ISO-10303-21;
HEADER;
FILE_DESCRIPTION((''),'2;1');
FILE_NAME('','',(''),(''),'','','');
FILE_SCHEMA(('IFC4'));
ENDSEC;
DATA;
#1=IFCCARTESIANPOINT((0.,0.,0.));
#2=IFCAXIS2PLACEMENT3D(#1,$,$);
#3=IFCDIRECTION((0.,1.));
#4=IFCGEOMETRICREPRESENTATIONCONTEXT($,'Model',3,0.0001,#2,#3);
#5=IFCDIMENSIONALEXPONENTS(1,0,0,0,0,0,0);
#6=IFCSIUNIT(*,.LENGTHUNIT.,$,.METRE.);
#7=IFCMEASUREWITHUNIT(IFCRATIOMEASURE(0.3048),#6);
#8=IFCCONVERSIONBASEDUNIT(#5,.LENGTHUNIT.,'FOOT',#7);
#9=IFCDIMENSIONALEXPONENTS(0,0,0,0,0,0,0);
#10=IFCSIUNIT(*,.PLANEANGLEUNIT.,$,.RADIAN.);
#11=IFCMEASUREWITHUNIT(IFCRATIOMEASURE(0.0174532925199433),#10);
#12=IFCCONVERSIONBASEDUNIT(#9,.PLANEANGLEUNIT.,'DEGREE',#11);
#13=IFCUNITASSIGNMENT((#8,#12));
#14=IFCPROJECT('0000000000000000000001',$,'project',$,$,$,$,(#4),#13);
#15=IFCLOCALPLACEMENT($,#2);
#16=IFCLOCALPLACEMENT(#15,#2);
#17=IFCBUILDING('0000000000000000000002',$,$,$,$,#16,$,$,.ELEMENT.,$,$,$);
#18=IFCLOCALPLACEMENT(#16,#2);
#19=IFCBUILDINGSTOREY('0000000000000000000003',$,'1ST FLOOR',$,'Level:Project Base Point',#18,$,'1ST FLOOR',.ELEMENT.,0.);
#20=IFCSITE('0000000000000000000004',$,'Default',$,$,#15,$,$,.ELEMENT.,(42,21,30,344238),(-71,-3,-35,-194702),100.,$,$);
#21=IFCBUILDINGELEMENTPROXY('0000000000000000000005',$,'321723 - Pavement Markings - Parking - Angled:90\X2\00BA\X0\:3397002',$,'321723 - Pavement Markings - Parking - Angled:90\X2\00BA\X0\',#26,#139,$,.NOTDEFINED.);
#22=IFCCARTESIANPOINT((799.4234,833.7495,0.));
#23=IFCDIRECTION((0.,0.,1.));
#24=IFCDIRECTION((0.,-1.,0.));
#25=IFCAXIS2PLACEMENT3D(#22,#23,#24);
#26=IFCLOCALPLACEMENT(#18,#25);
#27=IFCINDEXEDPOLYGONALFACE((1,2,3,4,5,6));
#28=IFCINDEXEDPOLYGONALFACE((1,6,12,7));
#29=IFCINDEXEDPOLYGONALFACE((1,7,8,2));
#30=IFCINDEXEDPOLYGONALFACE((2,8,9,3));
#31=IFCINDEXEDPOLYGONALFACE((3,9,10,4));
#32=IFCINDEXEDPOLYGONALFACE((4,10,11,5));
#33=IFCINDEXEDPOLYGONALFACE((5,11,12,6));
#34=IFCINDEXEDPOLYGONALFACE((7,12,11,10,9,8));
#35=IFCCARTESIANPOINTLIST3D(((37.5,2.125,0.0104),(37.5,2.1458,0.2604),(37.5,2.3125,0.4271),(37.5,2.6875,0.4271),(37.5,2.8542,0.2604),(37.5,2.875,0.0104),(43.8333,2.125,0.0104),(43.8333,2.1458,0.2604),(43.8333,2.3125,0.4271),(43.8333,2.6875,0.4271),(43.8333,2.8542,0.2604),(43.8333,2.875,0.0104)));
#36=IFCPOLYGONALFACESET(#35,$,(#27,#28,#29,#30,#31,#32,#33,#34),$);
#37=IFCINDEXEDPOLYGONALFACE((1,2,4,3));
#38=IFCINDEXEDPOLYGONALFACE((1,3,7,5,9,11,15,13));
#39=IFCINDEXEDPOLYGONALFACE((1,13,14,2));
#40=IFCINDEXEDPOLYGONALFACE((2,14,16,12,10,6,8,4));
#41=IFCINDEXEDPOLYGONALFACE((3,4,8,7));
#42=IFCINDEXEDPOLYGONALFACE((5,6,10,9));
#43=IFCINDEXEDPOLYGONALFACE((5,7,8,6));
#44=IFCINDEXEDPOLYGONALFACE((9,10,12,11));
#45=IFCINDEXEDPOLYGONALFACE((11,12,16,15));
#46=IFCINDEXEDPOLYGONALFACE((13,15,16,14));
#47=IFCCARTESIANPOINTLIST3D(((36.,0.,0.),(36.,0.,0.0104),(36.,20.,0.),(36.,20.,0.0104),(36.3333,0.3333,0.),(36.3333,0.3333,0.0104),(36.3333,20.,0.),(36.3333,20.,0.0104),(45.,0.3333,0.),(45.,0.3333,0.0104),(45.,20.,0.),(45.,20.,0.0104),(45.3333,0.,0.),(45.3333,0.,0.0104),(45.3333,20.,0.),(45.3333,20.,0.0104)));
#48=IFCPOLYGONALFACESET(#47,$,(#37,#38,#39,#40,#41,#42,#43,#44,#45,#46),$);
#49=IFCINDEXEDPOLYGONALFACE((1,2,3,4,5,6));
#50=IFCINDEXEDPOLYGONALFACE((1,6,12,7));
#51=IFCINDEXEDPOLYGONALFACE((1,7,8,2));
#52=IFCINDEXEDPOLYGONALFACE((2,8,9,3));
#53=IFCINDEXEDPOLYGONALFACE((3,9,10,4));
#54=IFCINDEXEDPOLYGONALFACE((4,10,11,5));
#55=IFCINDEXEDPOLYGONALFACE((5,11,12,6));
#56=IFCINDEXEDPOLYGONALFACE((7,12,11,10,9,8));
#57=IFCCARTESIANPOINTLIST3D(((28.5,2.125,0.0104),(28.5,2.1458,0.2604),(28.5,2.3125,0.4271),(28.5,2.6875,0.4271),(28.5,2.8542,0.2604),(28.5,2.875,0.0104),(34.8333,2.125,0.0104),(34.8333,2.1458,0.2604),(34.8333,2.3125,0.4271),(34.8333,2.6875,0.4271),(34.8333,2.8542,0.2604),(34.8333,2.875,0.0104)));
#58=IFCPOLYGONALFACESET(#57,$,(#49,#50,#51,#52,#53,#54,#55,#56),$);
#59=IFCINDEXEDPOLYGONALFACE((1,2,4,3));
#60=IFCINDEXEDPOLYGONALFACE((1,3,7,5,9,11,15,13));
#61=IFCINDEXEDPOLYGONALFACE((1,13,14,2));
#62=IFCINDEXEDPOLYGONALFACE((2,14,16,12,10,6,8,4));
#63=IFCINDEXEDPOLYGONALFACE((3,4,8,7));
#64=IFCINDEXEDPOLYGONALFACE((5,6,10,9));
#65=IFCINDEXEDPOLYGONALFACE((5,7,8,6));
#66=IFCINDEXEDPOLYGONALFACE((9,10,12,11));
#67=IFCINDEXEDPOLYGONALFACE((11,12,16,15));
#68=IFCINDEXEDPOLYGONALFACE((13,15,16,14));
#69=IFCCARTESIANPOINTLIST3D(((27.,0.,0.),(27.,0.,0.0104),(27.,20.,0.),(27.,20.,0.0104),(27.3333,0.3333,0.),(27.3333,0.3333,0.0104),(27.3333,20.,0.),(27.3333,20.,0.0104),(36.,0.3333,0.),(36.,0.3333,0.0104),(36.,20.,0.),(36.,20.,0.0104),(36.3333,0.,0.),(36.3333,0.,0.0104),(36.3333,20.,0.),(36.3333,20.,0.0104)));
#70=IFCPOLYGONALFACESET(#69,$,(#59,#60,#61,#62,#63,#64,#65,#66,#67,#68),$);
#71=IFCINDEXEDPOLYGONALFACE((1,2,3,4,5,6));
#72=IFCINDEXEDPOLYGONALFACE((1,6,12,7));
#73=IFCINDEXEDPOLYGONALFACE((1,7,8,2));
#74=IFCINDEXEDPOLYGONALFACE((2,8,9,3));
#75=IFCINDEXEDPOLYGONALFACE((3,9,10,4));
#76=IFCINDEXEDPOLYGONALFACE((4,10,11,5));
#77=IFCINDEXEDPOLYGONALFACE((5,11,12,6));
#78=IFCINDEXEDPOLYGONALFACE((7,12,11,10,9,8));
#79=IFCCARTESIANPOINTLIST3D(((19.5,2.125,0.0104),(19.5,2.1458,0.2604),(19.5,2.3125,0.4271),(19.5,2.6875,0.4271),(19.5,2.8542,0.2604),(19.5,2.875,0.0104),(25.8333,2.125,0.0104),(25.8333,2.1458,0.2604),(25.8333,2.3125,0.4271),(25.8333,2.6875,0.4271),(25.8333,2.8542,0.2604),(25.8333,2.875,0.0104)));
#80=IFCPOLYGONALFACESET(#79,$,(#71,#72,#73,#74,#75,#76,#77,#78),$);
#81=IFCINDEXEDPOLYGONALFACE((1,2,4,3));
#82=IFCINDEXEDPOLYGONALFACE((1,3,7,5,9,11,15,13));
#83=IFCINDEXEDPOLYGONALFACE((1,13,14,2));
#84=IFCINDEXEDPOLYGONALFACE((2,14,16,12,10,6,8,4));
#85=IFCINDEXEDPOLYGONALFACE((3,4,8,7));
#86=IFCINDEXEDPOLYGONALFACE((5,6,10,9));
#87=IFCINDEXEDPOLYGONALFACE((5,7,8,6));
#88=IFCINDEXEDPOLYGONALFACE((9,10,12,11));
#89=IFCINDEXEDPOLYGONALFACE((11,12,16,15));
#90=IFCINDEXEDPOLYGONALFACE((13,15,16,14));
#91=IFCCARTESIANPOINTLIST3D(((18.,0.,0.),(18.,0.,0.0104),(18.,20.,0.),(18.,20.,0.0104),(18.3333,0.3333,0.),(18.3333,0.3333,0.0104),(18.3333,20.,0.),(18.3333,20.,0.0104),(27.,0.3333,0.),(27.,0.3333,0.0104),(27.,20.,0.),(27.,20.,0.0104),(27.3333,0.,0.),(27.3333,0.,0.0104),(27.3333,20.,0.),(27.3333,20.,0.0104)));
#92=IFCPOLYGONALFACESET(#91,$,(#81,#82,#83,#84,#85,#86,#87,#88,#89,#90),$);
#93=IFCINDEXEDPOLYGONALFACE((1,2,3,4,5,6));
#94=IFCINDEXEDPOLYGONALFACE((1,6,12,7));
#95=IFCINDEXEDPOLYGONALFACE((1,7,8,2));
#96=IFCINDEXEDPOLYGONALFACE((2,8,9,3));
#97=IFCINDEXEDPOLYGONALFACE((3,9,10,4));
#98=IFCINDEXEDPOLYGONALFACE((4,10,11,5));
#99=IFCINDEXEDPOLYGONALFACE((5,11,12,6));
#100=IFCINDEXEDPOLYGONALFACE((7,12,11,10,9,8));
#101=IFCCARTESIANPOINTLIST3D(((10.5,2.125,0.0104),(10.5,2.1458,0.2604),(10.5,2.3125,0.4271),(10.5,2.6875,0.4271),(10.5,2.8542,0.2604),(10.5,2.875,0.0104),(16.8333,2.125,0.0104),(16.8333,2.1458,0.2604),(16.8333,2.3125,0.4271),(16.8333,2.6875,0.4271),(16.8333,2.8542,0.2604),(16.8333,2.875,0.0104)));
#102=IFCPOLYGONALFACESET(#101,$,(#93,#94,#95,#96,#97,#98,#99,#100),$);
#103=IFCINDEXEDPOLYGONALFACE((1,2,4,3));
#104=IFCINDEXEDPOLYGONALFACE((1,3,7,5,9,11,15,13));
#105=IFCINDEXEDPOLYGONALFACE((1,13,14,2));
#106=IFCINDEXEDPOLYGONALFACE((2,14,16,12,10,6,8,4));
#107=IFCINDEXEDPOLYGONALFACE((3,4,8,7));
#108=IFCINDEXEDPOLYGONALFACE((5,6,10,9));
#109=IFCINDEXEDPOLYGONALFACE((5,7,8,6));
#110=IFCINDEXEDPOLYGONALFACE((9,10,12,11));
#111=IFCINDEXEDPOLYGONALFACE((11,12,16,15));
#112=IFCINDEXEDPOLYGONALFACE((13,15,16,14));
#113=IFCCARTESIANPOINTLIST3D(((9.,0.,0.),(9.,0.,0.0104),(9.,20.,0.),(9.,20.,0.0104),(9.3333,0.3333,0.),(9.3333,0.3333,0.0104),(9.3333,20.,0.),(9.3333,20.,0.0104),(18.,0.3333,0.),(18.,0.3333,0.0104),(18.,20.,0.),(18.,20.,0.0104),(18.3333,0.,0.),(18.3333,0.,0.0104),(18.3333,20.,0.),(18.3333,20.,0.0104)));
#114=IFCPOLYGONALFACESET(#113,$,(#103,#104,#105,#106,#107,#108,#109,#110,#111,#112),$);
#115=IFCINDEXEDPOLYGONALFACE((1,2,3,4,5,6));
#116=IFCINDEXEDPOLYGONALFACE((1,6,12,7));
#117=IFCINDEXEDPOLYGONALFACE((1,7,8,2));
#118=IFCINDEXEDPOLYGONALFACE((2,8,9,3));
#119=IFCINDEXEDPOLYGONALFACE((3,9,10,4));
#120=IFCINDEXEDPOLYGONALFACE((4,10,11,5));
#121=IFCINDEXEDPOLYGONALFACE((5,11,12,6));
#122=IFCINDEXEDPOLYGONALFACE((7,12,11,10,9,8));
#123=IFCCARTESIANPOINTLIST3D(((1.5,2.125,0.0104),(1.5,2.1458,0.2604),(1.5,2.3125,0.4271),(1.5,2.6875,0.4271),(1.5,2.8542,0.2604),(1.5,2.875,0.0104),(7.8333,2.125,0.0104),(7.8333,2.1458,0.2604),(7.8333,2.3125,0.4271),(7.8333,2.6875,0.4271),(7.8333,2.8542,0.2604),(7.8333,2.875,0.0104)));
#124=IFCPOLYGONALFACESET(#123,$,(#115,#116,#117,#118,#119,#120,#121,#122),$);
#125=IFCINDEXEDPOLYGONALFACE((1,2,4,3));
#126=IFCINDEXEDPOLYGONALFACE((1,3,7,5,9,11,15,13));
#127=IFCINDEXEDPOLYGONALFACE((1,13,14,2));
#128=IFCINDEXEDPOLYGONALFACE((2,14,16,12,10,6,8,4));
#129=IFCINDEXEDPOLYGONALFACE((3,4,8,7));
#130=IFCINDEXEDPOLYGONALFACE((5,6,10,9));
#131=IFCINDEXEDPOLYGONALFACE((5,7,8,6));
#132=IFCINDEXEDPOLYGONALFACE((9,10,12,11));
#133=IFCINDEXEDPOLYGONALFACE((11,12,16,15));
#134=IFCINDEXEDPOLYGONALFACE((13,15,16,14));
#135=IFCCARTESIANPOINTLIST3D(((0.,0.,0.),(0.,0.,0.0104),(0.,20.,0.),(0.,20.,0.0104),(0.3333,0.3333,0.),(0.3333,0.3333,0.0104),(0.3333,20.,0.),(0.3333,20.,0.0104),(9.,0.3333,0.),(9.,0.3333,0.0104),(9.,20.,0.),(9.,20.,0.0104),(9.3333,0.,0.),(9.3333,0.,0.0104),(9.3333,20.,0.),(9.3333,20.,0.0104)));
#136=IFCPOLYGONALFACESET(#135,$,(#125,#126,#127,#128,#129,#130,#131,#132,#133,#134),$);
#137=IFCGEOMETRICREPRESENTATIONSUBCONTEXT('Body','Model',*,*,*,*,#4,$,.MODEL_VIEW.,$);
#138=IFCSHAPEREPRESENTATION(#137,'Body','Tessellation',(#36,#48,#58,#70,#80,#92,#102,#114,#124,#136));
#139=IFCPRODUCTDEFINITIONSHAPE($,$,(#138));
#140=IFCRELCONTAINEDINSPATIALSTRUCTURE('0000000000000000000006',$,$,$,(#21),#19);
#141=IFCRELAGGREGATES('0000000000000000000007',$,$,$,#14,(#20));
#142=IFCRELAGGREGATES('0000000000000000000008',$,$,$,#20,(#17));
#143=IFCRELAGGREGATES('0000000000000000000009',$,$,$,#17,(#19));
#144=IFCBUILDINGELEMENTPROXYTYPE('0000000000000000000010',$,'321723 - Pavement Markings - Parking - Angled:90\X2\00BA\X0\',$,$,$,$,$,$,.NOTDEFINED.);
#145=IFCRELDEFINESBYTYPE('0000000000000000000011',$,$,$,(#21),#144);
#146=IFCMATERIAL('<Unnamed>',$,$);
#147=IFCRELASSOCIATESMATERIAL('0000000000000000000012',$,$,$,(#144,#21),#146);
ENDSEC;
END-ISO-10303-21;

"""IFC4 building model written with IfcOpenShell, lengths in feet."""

from ifc_helpers import new_model, entity, si_unit, converted_unit, direction, frame, origin, place, context, subcontext, project, spatial, polyline, outline, extrude, source, transform, mapped, material, type_object, type_shapes, element, save


model = new_model("IFC4")

# Units and contexts
model_context = context("Model", 3, precision=0.0001, world=origin(), true_north=direction((0.0, 1.0)))
body_context = subcontext(model_context, "Body", "Model", "MODEL_VIEW")
ifc_project = project(units=[converted_unit("LENGTHUNIT", "FOOT", entity("IfcRatioMeasure", 0.3048), si_unit("LENGTHUNIT", "METRE"), dimensions=[1, 0, 0, 0, 0, 0, 0]), converted_unit("PLANEANGLEUNIT", "DEGREE", entity("IfcRatioMeasure", 0.0174532925199433), si_unit("PLANEANGLEUNIT", "RADIAN"), dimensions=[0, 0, 0, 0, 0, 0, 0])], contexts=[model_context])

# Site, building, storey
site_placement = place(None, origin())
site = spatial("IfcSite", under=ifc_project, at=site_placement, Name="Default", CompositionType="ELEMENT", RefLatitude=(42, 21, 30, 344238), RefLongitude=(-71, -3, -35, -194702), RefElevation=100.0)
building_placement = place(site_placement, origin())
building = spatial("IfcBuilding", under=site, at=building_placement, CompositionType="ELEMENT")
storey_placement = place(building_placement, origin())
storey = spatial("IfcBuildingStorey", under=building, at=storey_placement, Name="1ST FLOOR", ObjectType="Level:Project Base Point", LongName="1ST FLOOR", CompositionType="ELEMENT", Elevation=0.0)

# Building element proxy
ifc_material_1 = material(Name="<Unnamed>")
building_element_proxy_type_1 = type_object("IfcBuildingElementProxyType", Name="321723 - Pavement Markings - Parking - Angled:90º", PredefinedType="NOTDEFINED", material=ifc_material_1)
shared_shape_1 = source(origin(), body_context, "Body", "SweptSolid", [
    extrude(outline(polyline([(-0.375, -0.2222), (0.375, -0.2222), (0.3542, 0.0278), (0.1875, 0.1944), (-0.1875, 0.1944), (-0.3542, 0.0278), (-0.375, -0.2222)])), frame((37.5, 2.5, 0.2326), z_axis=(1.0, 0.0, 0.0), x_axis=(0.0, 1.0, 0.0)), (0.0, 0.0, 1.0), 6.3333),
    extrude(outline(polyline([(-4.6667, -10.0833), (4.6667, -10.0833), (4.6667, 9.9167), (4.3333, 9.9167), (4.3333, -9.75), (-4.3333, -9.75), (-4.3333, 9.9167), (-4.6667, 9.9167), (-4.6667, -10.0833)])), frame((40.6667, 10.0833, 0.0)), (0.0, 0.0, 1.0), 0.0104),
    extrude(outline(polyline([(-0.375, -0.2222), (0.375, -0.2222), (0.3542, 0.0278), (0.1875, 0.1944), (-0.1875, 0.1944), (-0.3542, 0.0278), (-0.375, -0.2222)])), frame((28.5, 2.5, 0.2326), z_axis=(1.0, 0.0, 0.0), x_axis=(0.0, 1.0, 0.0)), (0.0, 0.0, 1.0), 6.3333),
    extrude(outline(polyline([(-4.6667, -10.0833), (4.6667, -10.0833), (4.6667, 9.9167), (4.3333, 9.9167), (4.3333, -9.75), (-4.3333, -9.75), (-4.3333, 9.9167), (-4.6667, 9.9167), (-4.6667, -10.0833)])), frame((31.6667, 10.0833, 0.0)), (0.0, 0.0, 1.0), 0.0104),
    extrude(outline(polyline([(-0.375, -0.2222), (0.375, -0.2222), (0.3542, 0.0278), (0.1875, 0.1944), (-0.1875, 0.1944), (-0.3542, 0.0278), (-0.375, -0.2222)])), frame((19.5, 2.5, 0.2326), z_axis=(1.0, 0.0, 0.0), x_axis=(0.0, 1.0, 0.0)), (0.0, 0.0, 1.0), 6.3333),
    extrude(outline(polyline([(-4.6667, -10.0833), (4.6667, -10.0833), (4.6667, 9.9167), (4.3333, 9.9167), (4.3333, -9.75), (-4.3333, -9.75), (-4.3333, 9.9167), (-4.6667, 9.9167), (-4.6667, -10.0833)])), frame((22.6667, 10.0833, 0.0)), (0.0, 0.0, 1.0), 0.0104),
    extrude(outline(polyline([(-0.375, -0.2222), (0.375, -0.2222), (0.3542, 0.0278), (0.1875, 0.1944), (-0.1875, 0.1944), (-0.3542, 0.0278), (-0.375, -0.2222)])), frame((10.5, 2.5, 0.2326), z_axis=(1.0, 0.0, 0.0), x_axis=(0.0, 1.0, 0.0)), (0.0, 0.0, 1.0), 6.3333),
    extrude(outline(polyline([(-4.6667, -10.0833), (4.6667, -10.0833), (4.6667, 9.9167), (4.3333, 9.9167), (4.3333, -9.75), (-4.3333, -9.75), (-4.3333, 9.9167), (-4.6667, 9.9167), (-4.6667, -10.0833)])), frame((13.6667, 10.0833, 0.0)), (0.0, 0.0, 1.0), 0.0104),
    extrude(outline(polyline([(-0.375, -0.2222), (0.375, -0.2222), (0.3542, 0.0278), (0.1875, 0.1944), (-0.1875, 0.1944), (-0.3542, 0.0278), (-0.375, -0.2222)])), frame((1.5, 2.5, 0.2326), z_axis=(1.0, 0.0, 0.0), x_axis=(0.0, 1.0, 0.0)), (0.0, 0.0, 1.0), 6.3333),
    extrude(outline(polyline([(-4.6667, -10.0833), (4.6667, -10.0833), (4.6667, 9.9167), (4.3333, 9.9167), (4.3333, -9.75), (-4.3333, -9.75), (-4.3333, 9.9167), (-4.6667, 9.9167), (-4.6667, -10.0833)])), frame((4.6667, 10.0833, 0.0)), (0.0, 0.0, 1.0), 0.0104),
])
type_shapes(building_element_proxy_type_1, [shared_shape_1])
proxy_1_placement = place(storey_placement, frame((799.4234, 833.7495, 0.0), z_axis=(0.0, 0.0, 1.0), x_axis=(0.0, -1.0, 0.0)))
element("IfcBuildingElementProxy", 1, at=proxy_1_placement, inside=storey, type_object=building_element_proxy_type_1, material=ifc_material_1, Name="321723 - Pavement Markings - Parking - Angled:90º:3397002", ObjectType="321723 - Pavement Markings - Parking - Angled:90º", PredefinedType="NOTDEFINED", context=body_context, shape_type="MappedRepresentation", body=[
    mapped(shared_shape_1, transform((0.0, 0.0, 0.0), scale=1.0)),
])

save(model, "model.ifc")
